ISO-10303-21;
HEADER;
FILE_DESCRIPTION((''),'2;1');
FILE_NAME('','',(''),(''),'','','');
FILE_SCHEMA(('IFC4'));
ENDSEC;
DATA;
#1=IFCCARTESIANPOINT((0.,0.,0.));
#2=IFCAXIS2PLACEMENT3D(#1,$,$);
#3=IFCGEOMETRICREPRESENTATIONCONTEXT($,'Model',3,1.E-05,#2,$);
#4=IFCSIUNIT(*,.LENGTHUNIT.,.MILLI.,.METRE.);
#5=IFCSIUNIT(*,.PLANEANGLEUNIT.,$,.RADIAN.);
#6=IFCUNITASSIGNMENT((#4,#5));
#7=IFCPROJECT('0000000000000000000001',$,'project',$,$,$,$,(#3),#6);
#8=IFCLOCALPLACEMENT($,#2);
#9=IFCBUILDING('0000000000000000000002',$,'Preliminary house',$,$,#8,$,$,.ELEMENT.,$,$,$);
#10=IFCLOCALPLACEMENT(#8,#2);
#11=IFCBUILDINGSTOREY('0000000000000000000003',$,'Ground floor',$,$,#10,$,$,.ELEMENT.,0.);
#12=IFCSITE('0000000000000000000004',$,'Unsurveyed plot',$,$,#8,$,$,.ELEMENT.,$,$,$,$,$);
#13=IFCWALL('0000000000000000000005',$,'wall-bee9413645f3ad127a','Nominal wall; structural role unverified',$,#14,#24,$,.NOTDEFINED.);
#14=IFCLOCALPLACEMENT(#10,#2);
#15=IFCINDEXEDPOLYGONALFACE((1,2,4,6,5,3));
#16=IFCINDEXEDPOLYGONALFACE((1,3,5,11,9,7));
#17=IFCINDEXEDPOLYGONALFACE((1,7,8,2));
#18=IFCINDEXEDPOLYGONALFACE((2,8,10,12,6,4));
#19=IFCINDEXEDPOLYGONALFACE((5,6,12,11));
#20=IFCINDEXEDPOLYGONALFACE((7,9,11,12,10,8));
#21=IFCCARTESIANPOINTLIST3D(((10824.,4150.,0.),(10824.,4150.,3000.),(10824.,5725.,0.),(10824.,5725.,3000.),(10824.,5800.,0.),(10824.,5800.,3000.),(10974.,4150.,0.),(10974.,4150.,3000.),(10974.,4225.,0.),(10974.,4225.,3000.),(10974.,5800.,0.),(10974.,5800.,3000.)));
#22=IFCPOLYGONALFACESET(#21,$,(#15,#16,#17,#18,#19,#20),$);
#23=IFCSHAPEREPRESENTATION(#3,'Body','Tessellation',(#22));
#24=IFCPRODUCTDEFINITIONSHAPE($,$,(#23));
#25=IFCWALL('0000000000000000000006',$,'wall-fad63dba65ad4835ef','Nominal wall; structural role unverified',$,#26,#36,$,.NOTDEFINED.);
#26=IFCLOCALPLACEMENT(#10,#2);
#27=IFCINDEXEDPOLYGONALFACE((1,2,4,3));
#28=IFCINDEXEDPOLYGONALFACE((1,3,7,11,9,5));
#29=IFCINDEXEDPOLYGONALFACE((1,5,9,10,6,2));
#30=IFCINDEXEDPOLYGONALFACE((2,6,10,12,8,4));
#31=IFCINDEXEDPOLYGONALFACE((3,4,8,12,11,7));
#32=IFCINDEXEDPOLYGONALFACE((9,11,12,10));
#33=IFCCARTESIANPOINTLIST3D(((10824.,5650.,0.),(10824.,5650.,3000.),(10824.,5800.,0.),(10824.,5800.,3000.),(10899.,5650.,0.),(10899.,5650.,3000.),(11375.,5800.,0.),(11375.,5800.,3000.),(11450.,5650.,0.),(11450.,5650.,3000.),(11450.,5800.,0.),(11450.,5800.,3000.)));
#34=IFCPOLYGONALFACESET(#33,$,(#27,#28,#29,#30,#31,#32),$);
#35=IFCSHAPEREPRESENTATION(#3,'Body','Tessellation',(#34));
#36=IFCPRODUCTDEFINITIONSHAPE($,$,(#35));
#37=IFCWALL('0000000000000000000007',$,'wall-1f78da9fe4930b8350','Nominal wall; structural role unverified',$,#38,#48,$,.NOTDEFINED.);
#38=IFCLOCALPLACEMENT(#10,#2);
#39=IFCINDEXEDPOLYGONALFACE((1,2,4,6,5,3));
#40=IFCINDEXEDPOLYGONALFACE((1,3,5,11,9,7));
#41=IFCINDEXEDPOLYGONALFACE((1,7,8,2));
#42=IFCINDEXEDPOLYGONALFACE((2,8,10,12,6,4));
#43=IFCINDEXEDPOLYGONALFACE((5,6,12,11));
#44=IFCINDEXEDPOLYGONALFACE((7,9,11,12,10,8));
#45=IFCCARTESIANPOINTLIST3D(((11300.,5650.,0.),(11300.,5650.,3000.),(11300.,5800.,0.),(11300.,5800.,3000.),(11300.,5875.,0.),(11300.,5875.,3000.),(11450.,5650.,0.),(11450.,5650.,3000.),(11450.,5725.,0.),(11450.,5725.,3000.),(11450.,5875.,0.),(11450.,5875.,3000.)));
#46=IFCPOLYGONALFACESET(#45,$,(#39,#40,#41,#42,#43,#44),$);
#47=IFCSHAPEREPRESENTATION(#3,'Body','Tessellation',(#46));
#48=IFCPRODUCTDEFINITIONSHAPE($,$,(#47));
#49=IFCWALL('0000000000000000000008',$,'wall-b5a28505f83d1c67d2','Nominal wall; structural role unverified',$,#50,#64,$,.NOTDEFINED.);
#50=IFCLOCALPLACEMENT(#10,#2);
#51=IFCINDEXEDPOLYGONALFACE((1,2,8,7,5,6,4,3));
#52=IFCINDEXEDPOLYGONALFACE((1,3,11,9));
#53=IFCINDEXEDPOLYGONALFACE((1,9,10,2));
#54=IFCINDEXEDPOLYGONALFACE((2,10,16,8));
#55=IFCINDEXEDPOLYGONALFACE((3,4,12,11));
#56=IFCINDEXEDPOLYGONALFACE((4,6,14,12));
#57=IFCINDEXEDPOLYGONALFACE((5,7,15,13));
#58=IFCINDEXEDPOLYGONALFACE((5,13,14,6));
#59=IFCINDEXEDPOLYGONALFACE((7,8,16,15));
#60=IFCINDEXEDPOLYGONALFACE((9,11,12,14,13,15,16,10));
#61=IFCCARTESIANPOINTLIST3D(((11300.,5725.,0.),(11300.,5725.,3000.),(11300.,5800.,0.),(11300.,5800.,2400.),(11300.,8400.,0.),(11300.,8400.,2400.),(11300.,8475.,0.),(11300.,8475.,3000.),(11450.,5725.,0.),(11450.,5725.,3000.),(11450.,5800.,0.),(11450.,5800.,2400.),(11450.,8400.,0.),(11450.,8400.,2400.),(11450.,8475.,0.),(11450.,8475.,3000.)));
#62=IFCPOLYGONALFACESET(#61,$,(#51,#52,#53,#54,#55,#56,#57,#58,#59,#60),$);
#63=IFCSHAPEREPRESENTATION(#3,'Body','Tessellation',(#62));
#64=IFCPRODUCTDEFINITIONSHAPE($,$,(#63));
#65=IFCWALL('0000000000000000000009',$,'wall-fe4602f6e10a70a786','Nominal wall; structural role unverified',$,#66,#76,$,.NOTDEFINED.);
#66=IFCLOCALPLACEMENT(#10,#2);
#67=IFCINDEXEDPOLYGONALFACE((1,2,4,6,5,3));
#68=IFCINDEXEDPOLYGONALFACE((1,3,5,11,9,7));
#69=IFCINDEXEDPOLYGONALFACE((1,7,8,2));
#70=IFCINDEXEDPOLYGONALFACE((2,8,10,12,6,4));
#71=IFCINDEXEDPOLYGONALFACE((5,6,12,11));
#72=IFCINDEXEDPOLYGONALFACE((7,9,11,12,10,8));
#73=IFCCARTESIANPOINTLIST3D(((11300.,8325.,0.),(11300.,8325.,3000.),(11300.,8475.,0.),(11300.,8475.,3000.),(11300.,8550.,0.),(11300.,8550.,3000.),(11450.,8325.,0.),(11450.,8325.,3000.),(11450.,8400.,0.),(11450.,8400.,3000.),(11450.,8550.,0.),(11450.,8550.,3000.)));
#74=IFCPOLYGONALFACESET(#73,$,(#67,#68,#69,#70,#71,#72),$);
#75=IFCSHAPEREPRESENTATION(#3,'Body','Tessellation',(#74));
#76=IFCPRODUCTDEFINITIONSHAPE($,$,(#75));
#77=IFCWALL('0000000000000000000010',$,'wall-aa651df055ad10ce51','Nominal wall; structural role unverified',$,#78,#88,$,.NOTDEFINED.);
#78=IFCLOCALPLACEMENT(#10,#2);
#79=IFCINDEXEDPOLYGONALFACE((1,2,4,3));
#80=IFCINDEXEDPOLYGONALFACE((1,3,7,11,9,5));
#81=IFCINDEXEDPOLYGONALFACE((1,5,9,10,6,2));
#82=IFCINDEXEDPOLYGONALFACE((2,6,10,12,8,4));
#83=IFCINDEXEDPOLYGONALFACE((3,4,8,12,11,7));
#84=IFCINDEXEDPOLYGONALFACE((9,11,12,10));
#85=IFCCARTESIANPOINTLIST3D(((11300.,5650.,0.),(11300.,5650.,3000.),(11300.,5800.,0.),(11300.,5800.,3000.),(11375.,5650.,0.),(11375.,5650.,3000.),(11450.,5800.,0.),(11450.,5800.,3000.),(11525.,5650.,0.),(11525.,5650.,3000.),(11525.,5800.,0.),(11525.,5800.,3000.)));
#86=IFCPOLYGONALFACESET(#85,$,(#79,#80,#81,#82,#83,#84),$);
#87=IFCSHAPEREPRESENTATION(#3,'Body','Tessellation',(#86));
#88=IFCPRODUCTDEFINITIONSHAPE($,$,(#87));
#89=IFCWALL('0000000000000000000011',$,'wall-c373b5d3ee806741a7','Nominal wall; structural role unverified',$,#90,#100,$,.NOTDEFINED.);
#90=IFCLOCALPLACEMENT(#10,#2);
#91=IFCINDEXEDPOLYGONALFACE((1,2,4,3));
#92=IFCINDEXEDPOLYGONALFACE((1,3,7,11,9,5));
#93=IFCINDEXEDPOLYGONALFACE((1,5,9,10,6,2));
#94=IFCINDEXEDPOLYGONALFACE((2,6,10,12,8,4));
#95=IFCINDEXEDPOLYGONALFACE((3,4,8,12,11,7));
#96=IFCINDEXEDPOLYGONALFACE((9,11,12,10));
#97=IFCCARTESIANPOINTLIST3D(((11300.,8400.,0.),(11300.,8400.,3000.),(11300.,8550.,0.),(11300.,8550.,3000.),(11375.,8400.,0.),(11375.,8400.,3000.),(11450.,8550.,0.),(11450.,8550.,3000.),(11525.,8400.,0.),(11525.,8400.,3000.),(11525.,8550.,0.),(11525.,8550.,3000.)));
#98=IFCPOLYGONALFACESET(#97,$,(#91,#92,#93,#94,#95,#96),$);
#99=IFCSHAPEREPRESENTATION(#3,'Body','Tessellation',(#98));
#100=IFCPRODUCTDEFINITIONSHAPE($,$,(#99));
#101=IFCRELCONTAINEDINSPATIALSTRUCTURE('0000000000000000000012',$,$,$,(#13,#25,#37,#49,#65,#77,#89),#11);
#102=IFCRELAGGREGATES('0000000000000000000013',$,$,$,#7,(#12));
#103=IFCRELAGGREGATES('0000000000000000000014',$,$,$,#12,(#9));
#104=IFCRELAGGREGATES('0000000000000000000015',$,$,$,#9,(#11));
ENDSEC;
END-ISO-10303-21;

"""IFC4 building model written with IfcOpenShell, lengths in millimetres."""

from ifc_helpers import new_model, si_unit, origin, place, context, project, spatial, polyline, outline, extrude, element, save


model = new_model("IFC4")

# Units and contexts
model_context = context("Model", 3, precision=1e-05, world=origin())
ifc_project = project(units=[si_unit("LENGTHUNIT", "METRE", prefix="MILLI"), si_unit("PLANEANGLEUNIT", "RADIAN")], contexts=[model_context])

# Site, building, storey
placement_1 = place(None, origin())
site = spatial("IfcSite", under=ifc_project, at=placement_1, Name="Unsurveyed plot", CompositionType="ELEMENT")
building = spatial("IfcBuilding", under=site, at=placement_1, Name="Preliminary house", CompositionType="ELEMENT")
placement_2 = place(placement_1, origin())
storey = spatial("IfcBuildingStorey", under=building, at=placement_2, Name="Ground floor", CompositionType="ELEMENT", Elevation=0.0)

# Walls
element("IfcWall", 1, at=placement_2, inside=storey, Name="wall-bee9413645f3ad127a", Description="Nominal wall; structural role unverified", PredefinedType="NOTDEFINED", context=model_context, shape_type="SweptSolid", body=[
    extrude(outline(polyline([(10824.0, 5725.0), (10824.0, 5800.0), (10974.0, 5800.0), (10974.0, 4225.0), (10974.0, 4150.0), (10824.0, 4150.0), (10824.0, 5725.0)])), origin(), (0.0, 0.0, 1.0), 3000.0),
])
element("IfcWall", 2, at=placement_2, inside=storey, Name="wall-fad63dba65ad4835ef", Description="Nominal wall; structural role unverified", PredefinedType="NOTDEFINED", context=model_context, shape_type="SweptSolid", body=[
    extrude(outline(polyline([(11375.0, 5800.0), (11450.0, 5800.0), (11450.0, 5650.0), (10899.0, 5650.0), (10824.0, 5650.0), (10824.0, 5800.0), (11375.0, 5800.0)])), origin(), (0.0, 0.0, 1.0), 3000.0),
])
element("IfcWall", 3, at=placement_2, inside=storey, Name="wall-1f78da9fe4930b8350", Description="Nominal wall; structural role unverified", PredefinedType="NOTDEFINED", context=model_context, shape_type="SweptSolid", body=[
    extrude(outline(polyline([(11300.0, 5800.0), (11300.0, 5875.0), (11450.0, 5875.0), (11450.0, 5725.0), (11450.0, 5650.0), (11300.0, 5650.0), (11300.0, 5800.0)])), origin(), (0.0, 0.0, 1.0), 3000.0),
])

# Wall, opening
wall_1 = element("IfcWall", 4, at=placement_2, inside=storey, Name="wall-b5a28505f83d1c67d2", Description="Nominal wall; structural role unverified", PredefinedType="NOTDEFINED", context=model_context, shape_type="SweptSolid", body=[
    extrude(outline(polyline([(11300.0, 8400.0), (11300.0, 8475.0), (11450.0, 8475.0), (11450.0, 5800.0), (11450.0, 5725.0), (11300.0, 5725.0), (11300.0, 8400.0)])), origin(), (0.0, 0.0, 1.0), 3000.0),
])
element("IfcOpeningElement", 5, at=placement_2, cuts=wall_1, PredefinedType="OPENING", context=model_context, shape_type="SweptSolid", body=[
    extrude(outline(polyline([(11825.0, 5800.0), (11825.0, 8400.0), (10925.0, 8400.0), (10925.0, 5800.0), (11825.0, 5800.0)])), origin(), (0.0, 0.0, 1.0), 2400.0),
])

# Walls
element("IfcWall", 6, at=placement_2, inside=storey, Name="wall-fe4602f6e10a70a786", Description="Nominal wall; structural role unverified", PredefinedType="NOTDEFINED", context=model_context, shape_type="SweptSolid", body=[
    extrude(outline(polyline([(11300.0, 8475.0), (11300.0, 8550.0), (11450.0, 8550.0), (11450.0, 8400.0), (11450.0, 8325.0), (11300.0, 8325.0), (11300.0, 8475.0)])), origin(), (0.0, 0.0, 1.0), 3000.0),
])
element("IfcWall", 7, at=placement_2, inside=storey, Name="wall-aa651df055ad10ce51", Description="Nominal wall; structural role unverified", PredefinedType="NOTDEFINED", context=model_context, shape_type="SweptSolid", body=[
    extrude(outline(polyline([(11450.0, 5800.0), (11525.0, 5800.0), (11525.0, 5650.0), (11375.0, 5650.0), (11300.0, 5650.0), (11300.0, 5800.0), (11450.0, 5800.0)])), origin(), (0.0, 0.0, 1.0), 3000.0),
])

# Wall
element("IfcWall", 8, at=placement_2, inside=storey, Name="wall-c373b5d3ee806741a7", Description="Nominal wall; structural role unverified", PredefinedType="NOTDEFINED", context=model_context, shape_type="SweptSolid", body=[
    extrude(outline(polyline([(11450.0, 8550.0), (11525.0, 8550.0), (11525.0, 8400.0), (11375.0, 8400.0), (11300.0, 8400.0), (11300.0, 8550.0), (11450.0, 8550.0)])), origin(), (0.0, 0.0, 1.0), 3000.0),
])

save(model, "model.ifc")
